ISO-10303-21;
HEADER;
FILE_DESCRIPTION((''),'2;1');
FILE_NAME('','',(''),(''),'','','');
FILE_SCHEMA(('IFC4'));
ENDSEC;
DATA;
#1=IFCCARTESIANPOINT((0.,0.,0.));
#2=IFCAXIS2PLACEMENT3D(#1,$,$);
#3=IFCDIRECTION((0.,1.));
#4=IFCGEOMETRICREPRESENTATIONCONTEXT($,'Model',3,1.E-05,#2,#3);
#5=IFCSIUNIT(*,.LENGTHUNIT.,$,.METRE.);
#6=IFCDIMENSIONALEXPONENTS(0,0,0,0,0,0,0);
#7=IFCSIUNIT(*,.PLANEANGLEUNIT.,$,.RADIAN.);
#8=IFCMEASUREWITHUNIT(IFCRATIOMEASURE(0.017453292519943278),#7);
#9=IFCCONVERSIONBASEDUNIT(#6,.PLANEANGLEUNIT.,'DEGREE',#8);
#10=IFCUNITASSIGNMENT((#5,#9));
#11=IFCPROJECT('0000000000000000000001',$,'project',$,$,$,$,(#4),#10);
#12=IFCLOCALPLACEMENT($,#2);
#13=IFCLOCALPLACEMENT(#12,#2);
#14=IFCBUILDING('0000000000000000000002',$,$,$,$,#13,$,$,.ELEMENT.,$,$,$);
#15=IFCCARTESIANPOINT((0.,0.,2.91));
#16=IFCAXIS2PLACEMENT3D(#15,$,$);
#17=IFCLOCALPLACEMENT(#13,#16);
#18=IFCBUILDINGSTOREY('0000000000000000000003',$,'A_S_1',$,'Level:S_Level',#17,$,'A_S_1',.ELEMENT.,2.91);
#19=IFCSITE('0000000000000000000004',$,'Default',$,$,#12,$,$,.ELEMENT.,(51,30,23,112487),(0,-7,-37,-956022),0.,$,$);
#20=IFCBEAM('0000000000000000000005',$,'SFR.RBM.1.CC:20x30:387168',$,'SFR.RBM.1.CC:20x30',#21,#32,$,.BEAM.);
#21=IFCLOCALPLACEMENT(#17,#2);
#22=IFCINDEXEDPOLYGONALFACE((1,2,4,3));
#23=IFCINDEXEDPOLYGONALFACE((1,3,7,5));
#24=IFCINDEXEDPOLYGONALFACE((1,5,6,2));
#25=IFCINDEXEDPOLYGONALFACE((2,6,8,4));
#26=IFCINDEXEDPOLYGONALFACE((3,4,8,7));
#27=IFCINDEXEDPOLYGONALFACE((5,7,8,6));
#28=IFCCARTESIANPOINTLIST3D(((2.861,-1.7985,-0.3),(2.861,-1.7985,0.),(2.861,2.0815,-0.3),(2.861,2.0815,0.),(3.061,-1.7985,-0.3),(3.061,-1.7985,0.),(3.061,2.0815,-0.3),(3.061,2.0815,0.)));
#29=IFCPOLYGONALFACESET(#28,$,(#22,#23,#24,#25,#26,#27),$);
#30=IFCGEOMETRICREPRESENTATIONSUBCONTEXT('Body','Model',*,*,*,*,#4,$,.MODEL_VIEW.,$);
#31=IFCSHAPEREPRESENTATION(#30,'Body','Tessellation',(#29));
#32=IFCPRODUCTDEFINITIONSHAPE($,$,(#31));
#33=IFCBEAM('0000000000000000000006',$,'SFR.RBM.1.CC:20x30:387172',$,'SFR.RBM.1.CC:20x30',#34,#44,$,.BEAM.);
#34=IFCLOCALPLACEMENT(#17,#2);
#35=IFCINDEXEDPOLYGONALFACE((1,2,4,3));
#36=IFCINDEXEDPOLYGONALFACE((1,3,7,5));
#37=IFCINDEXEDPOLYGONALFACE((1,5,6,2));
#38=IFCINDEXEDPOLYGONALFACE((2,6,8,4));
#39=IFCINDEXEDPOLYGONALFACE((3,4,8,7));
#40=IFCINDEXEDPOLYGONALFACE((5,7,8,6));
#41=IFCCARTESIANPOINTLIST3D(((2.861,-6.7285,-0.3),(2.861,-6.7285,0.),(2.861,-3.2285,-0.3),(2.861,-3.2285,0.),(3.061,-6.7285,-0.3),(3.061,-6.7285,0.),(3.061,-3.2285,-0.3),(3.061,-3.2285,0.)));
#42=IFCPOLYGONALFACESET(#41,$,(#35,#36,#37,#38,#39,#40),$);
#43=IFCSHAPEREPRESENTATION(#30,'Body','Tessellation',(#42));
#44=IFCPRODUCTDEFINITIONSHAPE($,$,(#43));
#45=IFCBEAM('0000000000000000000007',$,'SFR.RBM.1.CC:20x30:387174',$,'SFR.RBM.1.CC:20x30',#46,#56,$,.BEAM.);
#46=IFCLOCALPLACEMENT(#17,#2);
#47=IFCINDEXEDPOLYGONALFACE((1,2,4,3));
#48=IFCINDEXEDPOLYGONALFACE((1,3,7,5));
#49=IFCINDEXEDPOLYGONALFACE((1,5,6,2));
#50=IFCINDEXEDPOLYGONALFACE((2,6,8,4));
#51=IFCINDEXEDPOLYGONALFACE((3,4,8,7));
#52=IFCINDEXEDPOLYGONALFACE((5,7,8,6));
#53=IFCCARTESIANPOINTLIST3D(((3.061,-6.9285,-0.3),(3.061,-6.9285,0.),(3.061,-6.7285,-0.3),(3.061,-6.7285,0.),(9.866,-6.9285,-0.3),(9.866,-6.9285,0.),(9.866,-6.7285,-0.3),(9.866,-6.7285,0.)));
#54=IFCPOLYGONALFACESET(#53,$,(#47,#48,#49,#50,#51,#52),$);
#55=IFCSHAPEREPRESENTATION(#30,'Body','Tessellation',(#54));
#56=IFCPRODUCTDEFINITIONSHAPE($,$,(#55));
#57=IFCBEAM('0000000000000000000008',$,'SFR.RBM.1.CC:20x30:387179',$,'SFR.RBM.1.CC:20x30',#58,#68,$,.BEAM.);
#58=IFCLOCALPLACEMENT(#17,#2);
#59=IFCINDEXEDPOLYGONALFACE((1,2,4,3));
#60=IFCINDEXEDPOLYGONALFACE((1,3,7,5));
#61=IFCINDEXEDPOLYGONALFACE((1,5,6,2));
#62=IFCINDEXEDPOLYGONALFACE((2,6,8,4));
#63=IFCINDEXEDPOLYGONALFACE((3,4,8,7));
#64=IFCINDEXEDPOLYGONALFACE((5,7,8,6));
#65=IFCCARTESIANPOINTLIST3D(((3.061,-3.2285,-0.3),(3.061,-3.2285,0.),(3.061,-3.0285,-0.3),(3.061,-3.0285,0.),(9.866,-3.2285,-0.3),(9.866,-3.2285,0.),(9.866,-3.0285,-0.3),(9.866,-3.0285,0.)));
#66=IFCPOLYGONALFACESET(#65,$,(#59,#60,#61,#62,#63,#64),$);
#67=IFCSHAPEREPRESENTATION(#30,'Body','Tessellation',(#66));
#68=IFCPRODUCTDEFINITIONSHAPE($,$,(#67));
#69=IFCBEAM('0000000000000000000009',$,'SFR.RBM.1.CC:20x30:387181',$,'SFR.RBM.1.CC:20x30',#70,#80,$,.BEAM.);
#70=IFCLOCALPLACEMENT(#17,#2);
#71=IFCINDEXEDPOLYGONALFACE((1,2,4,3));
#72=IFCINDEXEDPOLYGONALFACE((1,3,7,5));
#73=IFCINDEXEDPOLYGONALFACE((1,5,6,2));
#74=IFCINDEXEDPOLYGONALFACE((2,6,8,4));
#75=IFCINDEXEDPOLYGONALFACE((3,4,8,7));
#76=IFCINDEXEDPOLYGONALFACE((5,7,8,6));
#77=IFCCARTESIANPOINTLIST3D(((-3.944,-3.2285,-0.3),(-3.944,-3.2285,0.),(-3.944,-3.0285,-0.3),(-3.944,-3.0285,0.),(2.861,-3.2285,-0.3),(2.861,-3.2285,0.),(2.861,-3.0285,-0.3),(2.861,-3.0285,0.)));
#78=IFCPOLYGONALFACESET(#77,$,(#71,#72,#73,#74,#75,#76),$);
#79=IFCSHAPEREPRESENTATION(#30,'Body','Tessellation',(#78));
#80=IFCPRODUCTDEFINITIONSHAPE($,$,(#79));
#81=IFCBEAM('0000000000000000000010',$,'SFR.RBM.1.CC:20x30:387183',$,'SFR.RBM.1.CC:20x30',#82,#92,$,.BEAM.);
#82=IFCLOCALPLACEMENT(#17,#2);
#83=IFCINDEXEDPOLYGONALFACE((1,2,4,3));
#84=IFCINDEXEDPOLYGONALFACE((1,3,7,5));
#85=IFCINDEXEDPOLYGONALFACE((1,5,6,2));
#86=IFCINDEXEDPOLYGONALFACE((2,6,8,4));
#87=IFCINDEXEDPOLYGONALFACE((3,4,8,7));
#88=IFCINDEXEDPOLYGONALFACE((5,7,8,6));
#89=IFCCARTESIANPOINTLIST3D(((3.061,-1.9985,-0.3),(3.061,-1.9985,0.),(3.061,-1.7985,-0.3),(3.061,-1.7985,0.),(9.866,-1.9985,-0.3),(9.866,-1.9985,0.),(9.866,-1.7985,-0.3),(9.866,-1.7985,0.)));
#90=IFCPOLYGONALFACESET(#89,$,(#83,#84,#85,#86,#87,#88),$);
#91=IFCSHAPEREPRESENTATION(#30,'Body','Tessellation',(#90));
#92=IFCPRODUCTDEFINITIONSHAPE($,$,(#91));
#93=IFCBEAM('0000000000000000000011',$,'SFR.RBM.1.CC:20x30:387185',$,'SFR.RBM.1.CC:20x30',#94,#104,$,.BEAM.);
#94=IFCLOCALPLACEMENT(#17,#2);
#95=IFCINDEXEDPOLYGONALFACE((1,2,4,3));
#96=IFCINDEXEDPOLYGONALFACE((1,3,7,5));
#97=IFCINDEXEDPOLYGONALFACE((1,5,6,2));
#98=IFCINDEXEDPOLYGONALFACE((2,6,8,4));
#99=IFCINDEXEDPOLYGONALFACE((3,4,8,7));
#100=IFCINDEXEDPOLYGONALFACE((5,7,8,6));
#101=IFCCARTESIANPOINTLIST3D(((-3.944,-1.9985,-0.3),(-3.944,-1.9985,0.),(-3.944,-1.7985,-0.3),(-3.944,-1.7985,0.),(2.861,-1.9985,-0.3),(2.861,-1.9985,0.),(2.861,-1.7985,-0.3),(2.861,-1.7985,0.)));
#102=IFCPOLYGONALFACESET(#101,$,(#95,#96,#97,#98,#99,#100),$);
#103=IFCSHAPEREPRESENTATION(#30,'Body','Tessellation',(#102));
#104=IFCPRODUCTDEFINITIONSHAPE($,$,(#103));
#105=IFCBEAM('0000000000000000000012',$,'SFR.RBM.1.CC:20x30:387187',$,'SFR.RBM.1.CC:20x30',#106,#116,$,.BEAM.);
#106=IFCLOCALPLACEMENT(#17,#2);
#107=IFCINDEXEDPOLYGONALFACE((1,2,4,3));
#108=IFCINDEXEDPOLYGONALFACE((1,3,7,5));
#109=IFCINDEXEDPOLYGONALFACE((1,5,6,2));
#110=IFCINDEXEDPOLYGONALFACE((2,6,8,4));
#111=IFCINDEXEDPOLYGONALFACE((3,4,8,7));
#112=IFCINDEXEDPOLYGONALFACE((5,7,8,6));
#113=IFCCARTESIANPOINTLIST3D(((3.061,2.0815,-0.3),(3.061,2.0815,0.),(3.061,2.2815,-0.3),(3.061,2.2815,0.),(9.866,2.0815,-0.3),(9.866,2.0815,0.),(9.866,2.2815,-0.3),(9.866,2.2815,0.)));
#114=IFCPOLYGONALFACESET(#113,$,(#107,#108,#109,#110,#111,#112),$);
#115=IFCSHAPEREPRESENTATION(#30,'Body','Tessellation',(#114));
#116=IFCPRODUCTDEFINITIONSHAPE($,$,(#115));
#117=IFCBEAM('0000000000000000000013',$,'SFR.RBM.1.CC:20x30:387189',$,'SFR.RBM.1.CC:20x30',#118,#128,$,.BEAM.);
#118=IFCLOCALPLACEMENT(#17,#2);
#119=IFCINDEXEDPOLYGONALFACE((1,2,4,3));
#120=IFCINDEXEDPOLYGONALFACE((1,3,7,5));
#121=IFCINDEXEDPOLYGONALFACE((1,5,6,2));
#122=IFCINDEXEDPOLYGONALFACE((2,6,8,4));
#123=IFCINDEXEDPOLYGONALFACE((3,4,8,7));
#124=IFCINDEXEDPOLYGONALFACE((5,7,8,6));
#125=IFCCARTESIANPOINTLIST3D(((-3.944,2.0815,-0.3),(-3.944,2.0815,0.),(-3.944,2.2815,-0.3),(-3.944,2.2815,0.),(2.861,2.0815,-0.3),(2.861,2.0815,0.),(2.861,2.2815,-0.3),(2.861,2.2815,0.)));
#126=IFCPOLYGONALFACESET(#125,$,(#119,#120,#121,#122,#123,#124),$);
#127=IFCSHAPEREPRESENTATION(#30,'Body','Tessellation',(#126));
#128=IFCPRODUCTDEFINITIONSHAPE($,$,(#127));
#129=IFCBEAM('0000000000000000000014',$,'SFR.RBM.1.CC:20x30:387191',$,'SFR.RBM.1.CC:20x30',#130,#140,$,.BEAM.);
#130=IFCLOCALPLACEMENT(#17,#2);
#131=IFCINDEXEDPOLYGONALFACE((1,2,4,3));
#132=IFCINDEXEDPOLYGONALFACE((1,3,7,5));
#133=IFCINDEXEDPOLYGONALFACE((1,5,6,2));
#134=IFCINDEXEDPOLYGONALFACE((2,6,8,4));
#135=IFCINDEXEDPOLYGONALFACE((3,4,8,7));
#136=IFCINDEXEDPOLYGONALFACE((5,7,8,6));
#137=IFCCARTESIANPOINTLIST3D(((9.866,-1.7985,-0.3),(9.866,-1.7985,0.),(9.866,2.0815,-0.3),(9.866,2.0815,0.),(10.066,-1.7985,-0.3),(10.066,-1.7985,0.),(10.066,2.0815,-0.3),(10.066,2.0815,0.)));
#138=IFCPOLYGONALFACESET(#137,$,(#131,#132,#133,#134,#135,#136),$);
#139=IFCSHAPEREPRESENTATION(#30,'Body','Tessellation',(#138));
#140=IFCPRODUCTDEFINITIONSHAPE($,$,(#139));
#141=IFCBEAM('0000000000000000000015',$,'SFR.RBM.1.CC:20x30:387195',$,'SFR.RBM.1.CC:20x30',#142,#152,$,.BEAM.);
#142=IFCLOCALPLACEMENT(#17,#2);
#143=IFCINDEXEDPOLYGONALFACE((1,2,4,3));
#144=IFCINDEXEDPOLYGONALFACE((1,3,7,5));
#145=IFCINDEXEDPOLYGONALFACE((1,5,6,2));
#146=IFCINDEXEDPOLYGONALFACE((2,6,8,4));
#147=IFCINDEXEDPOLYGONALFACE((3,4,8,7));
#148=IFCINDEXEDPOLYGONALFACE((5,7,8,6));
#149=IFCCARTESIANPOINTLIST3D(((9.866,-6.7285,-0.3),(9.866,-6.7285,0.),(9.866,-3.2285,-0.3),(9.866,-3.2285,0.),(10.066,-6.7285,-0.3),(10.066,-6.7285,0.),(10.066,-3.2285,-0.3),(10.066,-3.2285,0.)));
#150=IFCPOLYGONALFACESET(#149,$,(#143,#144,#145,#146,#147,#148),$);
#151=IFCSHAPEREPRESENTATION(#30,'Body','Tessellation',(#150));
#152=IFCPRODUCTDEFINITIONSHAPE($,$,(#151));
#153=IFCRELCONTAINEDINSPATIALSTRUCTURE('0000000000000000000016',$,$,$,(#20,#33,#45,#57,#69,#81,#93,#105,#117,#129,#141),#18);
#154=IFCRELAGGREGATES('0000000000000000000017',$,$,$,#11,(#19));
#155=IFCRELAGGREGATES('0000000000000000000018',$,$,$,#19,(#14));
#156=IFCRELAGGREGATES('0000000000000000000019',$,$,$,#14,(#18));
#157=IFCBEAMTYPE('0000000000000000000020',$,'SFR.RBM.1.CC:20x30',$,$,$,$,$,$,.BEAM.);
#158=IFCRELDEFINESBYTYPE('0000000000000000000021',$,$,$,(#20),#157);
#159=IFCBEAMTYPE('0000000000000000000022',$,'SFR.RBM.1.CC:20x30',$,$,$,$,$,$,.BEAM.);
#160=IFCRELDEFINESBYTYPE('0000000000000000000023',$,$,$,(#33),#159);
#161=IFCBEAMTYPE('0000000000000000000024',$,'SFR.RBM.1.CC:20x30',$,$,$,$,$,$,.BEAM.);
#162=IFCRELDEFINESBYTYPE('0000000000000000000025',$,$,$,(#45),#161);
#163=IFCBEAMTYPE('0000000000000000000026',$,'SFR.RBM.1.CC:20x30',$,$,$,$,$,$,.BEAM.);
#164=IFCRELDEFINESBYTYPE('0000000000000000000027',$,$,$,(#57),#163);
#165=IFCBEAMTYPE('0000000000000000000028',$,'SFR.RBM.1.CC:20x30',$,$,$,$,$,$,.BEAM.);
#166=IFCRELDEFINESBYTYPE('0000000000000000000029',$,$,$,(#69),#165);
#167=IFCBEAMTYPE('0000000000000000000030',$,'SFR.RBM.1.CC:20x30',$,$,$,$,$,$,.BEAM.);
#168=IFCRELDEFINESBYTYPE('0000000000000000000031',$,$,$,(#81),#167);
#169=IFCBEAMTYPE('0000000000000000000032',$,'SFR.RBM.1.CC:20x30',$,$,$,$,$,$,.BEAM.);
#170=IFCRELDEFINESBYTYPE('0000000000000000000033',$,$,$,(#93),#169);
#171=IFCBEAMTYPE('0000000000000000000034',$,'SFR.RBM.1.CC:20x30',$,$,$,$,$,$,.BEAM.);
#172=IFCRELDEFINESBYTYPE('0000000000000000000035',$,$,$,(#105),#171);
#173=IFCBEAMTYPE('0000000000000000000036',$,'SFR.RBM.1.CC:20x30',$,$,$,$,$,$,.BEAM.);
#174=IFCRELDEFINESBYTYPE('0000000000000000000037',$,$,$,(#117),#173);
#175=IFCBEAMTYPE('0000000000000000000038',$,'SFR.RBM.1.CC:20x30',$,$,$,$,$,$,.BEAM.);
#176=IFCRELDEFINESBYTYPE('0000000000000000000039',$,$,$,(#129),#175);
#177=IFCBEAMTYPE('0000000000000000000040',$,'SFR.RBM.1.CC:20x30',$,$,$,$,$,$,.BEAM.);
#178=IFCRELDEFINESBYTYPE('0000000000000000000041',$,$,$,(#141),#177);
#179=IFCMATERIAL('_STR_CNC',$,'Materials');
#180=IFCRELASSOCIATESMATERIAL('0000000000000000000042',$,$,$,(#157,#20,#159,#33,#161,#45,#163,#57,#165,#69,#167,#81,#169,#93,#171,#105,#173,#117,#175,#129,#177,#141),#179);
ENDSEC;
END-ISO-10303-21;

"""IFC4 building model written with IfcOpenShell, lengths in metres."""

from ifc_helpers import new_model, entity, si_unit, converted_unit, direction, frame, origin, place, context, subcontext, project, spatial, indexed_curve, outline, extrude, source, transform, mapped, material, type_object, type_shapes, element, save


model = new_model("IFC4")

# Units and contexts
model_context = context("Model", 3, precision=1e-05, world=origin(), true_north=direction((0.0, 1.0)))
body_context = subcontext(model_context, "Body", "Model", "MODEL_VIEW")
ifc_project = project(units=[si_unit("LENGTHUNIT", "METRE"), converted_unit("PLANEANGLEUNIT", "DEGREE", entity("IfcRatioMeasure", 0.017453292519943278), si_unit("PLANEANGLEUNIT", "RADIAN"), dimensions=[0, 0, 0, 0, 0, 0, 0])], contexts=[model_context])

# Site, building, storey
site_placement = place(None, origin())
site = spatial("IfcSite", under=ifc_project, at=site_placement, Name="Default", CompositionType="ELEMENT", RefLatitude=(51, 30, 23, 112487), RefLongitude=(0, -7, -37, -956022), RefElevation=0.0)
building_placement = place(site_placement, origin())
building = spatial("IfcBuilding", under=site, at=building_placement, CompositionType="ELEMENT")
storey_placement = place(building_placement, frame((0.0, 0.0, 2.91)))
storey = spatial("IfcBuildingStorey", under=building, at=storey_placement, Name="A_S_1", ObjectType="Level:S_Level", LongName="A_S_1", CompositionType="ELEMENT", Elevation=2.91)

# Shared definitions
ifc_material_1 = material(Name="_STR_CNC", Category="Materials")

# Beams
beam_type_1 = type_object("IfcBeamType", Name="SFR.RBM.1.CC:20x30", PredefinedType="BEAM", material=ifc_material_1)
shared_shape_1 = source(origin(), body_context, "Body", "SweptSolid", [
    extrude(outline(indexed_curve([(-0.1, -0.15), (0.1, -0.15), (0.1, 0.15), (-0.1, 0.15), (-0.1, -0.15)], self_intersect=False)), frame((2.961, 2.0815, 2.76), z_axis=(0.0, -1.0, 0.0), x_axis=(-1.0, 0.0, 0.0)), (0.0, 0.0, 1.0), 3.88),
])
type_shapes(beam_type_1, [shared_shape_1])
beam_1_placement = place(storey_placement, frame((0.0, 0.0, -2.91)))
element("IfcBeam", 1, at=beam_1_placement, inside=storey, type_object=beam_type_1, material=ifc_material_1, Name="SFR.RBM.1.CC:20x30:387168", ObjectType="SFR.RBM.1.CC:20x30", PredefinedType="BEAM", context=body_context, shape_type="MappedRepresentation", body=[
    mapped(shared_shape_1, transform((0.0, 0.0, 0.0), scale=1.0)),
])
beam_type_2 = type_object("IfcBeamType", Name="SFR.RBM.1.CC:20x30", PredefinedType="BEAM", material=ifc_material_1)
shared_shape_2 = source(origin(), body_context, "Body", "SweptSolid", [
    extrude(outline(indexed_curve([(-0.1, -0.15), (0.1, -0.15), (0.1, 0.15), (-0.1, 0.15), (-0.1, -0.15)], self_intersect=False)), frame((2.961, -3.2285, 2.76), z_axis=(0.0, -1.0, 0.0), x_axis=(-1.0, 0.0, 0.0)), (0.0, 0.0, 1.0), 3.5),
])
type_shapes(beam_type_2, [shared_shape_2])
beam_2_placement = place(storey_placement, frame((0.0, 0.0, -2.91)))
element("IfcBeam", 2, at=beam_2_placement, inside=storey, type_object=beam_type_2, material=ifc_material_1, Name="SFR.RBM.1.CC:20x30:387172", ObjectType="SFR.RBM.1.CC:20x30", PredefinedType="BEAM", context=body_context, shape_type="MappedRepresentation", body=[
    mapped(shared_shape_2, transform((0.0, 0.0, 0.0), scale=1.0)),
])
beam_type_3 = type_object("IfcBeamType", Name="SFR.RBM.1.CC:20x30", PredefinedType="BEAM", material=ifc_material_1)
shared_shape_3 = source(origin(), body_context, "Body", "SweptSolid", [
    extrude(outline(indexed_curve([(-0.15, -0.1), (0.15, -0.1), (0.15, 0.1), (-0.15, 0.1), (-0.15, -0.1)], self_intersect=False)), frame((9.866, -6.8285, 2.76), z_axis=(-1.0, 0.0, 0.0), x_axis=(0.0, 0.0, -1.0)), (0.0, 0.0, 1.0), 6.805),
])
type_shapes(beam_type_3, [shared_shape_3])
beam_3_placement = place(storey_placement, frame((0.0, 0.0, -2.91)))
element("IfcBeam", 3, at=beam_3_placement, inside=storey, type_object=beam_type_3, material=ifc_material_1, Name="SFR.RBM.1.CC:20x30:387174", ObjectType="SFR.RBM.1.CC:20x30", PredefinedType="BEAM", context=body_context, shape_type="MappedRepresentation", body=[
    mapped(shared_shape_3, transform((0.0, 0.0, 0.0), scale=1.0)),
])
beam_type_4 = type_object("IfcBeamType", Name="SFR.RBM.1.CC:20x30", PredefinedType="BEAM", material=ifc_material_1)
shared_shape_4 = source(origin(), body_context, "Body", "SweptSolid", [
    extrude(outline(indexed_curve([(-0.15, -0.1), (0.15, -0.1), (0.15, 0.1), (-0.15, 0.1), (-0.15, -0.1)], self_intersect=False)), frame((9.866, -3.1285, 2.76), z_axis=(-1.0, 0.0, 0.0), x_axis=(0.0, 0.0, -1.0)), (0.0, 0.0, 1.0), 6.805),
])
type_shapes(beam_type_4, [shared_shape_4])
beam_4_placement = place(storey_placement, frame((0.0, 0.0, -2.91)))
element("IfcBeam", 4, at=beam_4_placement, inside=storey, type_object=beam_type_4, material=ifc_material_1, Name="SFR.RBM.1.CC:20x30:387179", ObjectType="SFR.RBM.1.CC:20x30", PredefinedType="BEAM", context=body_context, shape_type="MappedRepresentation", body=[
    mapped(shared_shape_4, transform((0.0, 0.0, 0.0), scale=1.0)),
])
beam_type_5 = type_object("IfcBeamType", Name="SFR.RBM.1.CC:20x30", PredefinedType="BEAM", material=ifc_material_1)
shared_shape_5 = source(origin(), body_context, "Body", "SweptSolid", [
    extrude(outline(indexed_curve([(-0.15, -0.1), (0.15, -0.1), (0.15, 0.1), (-0.15, 0.1), (-0.15, -0.1)], self_intersect=False)), frame((2.861, -3.1285, 2.76), z_axis=(-1.0, 0.0, 0.0), x_axis=(0.0, 0.0, -1.0)), (0.0, 0.0, 1.0), 6.805),
])
type_shapes(beam_type_5, [shared_shape_5])
beam_5_placement = place(storey_placement, frame((0.0, 0.0, -2.91)))
element("IfcBeam", 5, at=beam_5_placement, inside=storey, type_object=beam_type_5, material=ifc_material_1, Name="SFR.RBM.1.CC:20x30:387181", ObjectType="SFR.RBM.1.CC:20x30", PredefinedType="BEAM", context=body_context, shape_type="MappedRepresentation", body=[
    mapped(shared_shape_5, transform((0.0, 0.0, 0.0), scale=1.0)),
])
beam_type_6 = type_object("IfcBeamType", Name="SFR.RBM.1.CC:20x30", PredefinedType="BEAM", material=ifc_material_1)
shared_shape_6 = source(origin(), body_context, "Body", "SweptSolid", [
    extrude(outline(indexed_curve([(-0.15, -0.1), (0.15, -0.1), (0.15, 0.1), (-0.15, 0.1), (-0.15, -0.1)], self_intersect=False)), frame((9.866, -1.8985, 2.76), z_axis=(-1.0, 0.0, 0.0), x_axis=(0.0, 0.0, -1.0)), (0.0, 0.0, 1.0), 6.805),
])
type_shapes(beam_type_6, [shared_shape_6])
beam_6_placement = place(storey_placement, frame((0.0, 0.0, -2.91)))
element("IfcBeam", 6, at=beam_6_placement, inside=storey, type_object=beam_type_6, material=ifc_material_1, Name="SFR.RBM.1.CC:20x30:387183", ObjectType="SFR.RBM.1.CC:20x30", PredefinedType="BEAM", context=body_context, shape_type="MappedRepresentation", body=[
    mapped(shared_shape_6, transform((0.0, 0.0, 0.0), scale=1.0)),
])
beam_type_7 = type_object("IfcBeamType", Name="SFR.RBM.1.CC:20x30", PredefinedType="BEAM", material=ifc_material_1)
shared_shape_7 = source(origin(), body_context, "Body", "SweptSolid", [
    extrude(outline(indexed_curve([(-0.15, -0.1), (0.15, -0.1), (0.15, 0.1), (-0.15, 0.1), (-0.15, -0.1)], self_intersect=False)), frame((2.861, -1.8985, 2.76), z_axis=(-1.0, 0.0, 0.0), x_axis=(0.0, 0.0, -1.0)), (0.0, 0.0, 1.0), 6.805),
])
type_shapes(beam_type_7, [shared_shape_7])
beam_7_placement = place(storey_placement, frame((0.0, 0.0, -2.91)))
element("IfcBeam", 7, at=beam_7_placement, inside=storey, type_object=beam_type_7, material=ifc_material_1, Name="SFR.RBM.1.CC:20x30:387185", ObjectType="SFR.RBM.1.CC:20x30", PredefinedType="BEAM", context=body_context, shape_type="MappedRepresentation", body=[
    mapped(shared_shape_7, transform((0.0, 0.0, 0.0), scale=1.0)),
])
beam_type_8 = type_object("IfcBeamType", Name="SFR.RBM.1.CC:20x30", PredefinedType="BEAM", material=ifc_material_1)
shared_shape_8 = source(origin(), body_context, "Body", "SweptSolid", [
    extrude(outline(indexed_curve([(-0.15, -0.1), (0.15, -0.1), (0.15, 0.1), (-0.15, 0.1), (-0.15, -0.1)], self_intersect=False)), frame((9.866, 2.1815, 2.76), z_axis=(-1.0, 0.0, 0.0), x_axis=(0.0, 0.0, -1.0)), (0.0, 0.0, 1.0), 6.805),
])
type_shapes(beam_type_8, [shared_shape_8])
beam_8_placement = place(storey_placement, frame((0.0, 0.0, -2.91)))
element("IfcBeam", 8, at=beam_8_placement, inside=storey, type_object=beam_type_8, material=ifc_material_1, Name="SFR.RBM.1.CC:20x30:387187", ObjectType="SFR.RBM.1.CC:20x30", PredefinedType="BEAM", context=body_context, shape_type="MappedRepresentation", body=[
    mapped(shared_shape_8, transform((0.0, 0.0, 0.0), scale=1.0)),
])
beam_type_9 = type_object("IfcBeamType", Name="SFR.RBM.1.CC:20x30", PredefinedType="BEAM", material=ifc_material_1)
shared_shape_9 = source(origin(), body_context, "Body", "SweptSolid", [
    extrude(outline(indexed_curve([(-0.15, -0.1), (0.15, -0.1), (0.15, 0.1), (-0.15, 0.1), (-0.15, -0.1)], self_intersect=False)), frame((2.861, 2.1815, 2.76), z_axis=(-1.0, 0.0, 0.0), x_axis=(0.0, 0.0, -1.0)), (0.0, 0.0, 1.0), 6.805),
])
type_shapes(beam_type_9, [shared_shape_9])
beam_9_placement = place(storey_placement, frame((0.0, 0.0, -2.91)))
element("IfcBeam", 9, at=beam_9_placement, inside=storey, type_object=beam_type_9, material=ifc_material_1, Name="SFR.RBM.1.CC:20x30:387189", ObjectType="SFR.RBM.1.CC:20x30", PredefinedType="BEAM", context=body_context, shape_type="MappedRepresentation", body=[
    mapped(shared_shape_9, transform((0.0, 0.0, 0.0), scale=1.0)),
])
beam_type_10 = type_object("IfcBeamType", Name="SFR.RBM.1.CC:20x30", PredefinedType="BEAM", material=ifc_material_1)
shared_shape_10 = source(origin(), body_context, "Body", "SweptSolid", [
    extrude(outline(indexed_curve([(-0.1, -0.15), (0.1, -0.15), (0.1, 0.15), (-0.1, 0.15), (-0.1, -0.15)], self_intersect=False)), frame((9.966, 2.0815, 2.76), z_axis=(0.0, -1.0, 0.0), x_axis=(-1.0, 0.0, 0.0)), (0.0, 0.0, 1.0), 3.88),
])
type_shapes(beam_type_10, [shared_shape_10])
beam_10_placement = place(storey_placement, frame((0.0, 0.0, -2.91)))
element("IfcBeam", 10, at=beam_10_placement, inside=storey, type_object=beam_type_10, material=ifc_material_1, Name="SFR.RBM.1.CC:20x30:387191", ObjectType="SFR.RBM.1.CC:20x30", PredefinedType="BEAM", context=body_context, shape_type="MappedRepresentation", body=[
    mapped(shared_shape_10, transform((0.0, 0.0, 0.0), scale=1.0)),
])
beam_type_11 = type_object("IfcBeamType", Name="SFR.RBM.1.CC:20x30", PredefinedType="BEAM", material=ifc_material_1)
shared_shape_11 = source(origin(), body_context, "Body", "SweptSolid", [
    extrude(outline(indexed_curve([(-0.1, -0.15), (0.1, -0.15), (0.1, 0.15), (-0.1, 0.15), (-0.1, -0.15)], self_intersect=False)), frame((9.966, -3.2285, 2.76), z_axis=(0.0, -1.0, 0.0), x_axis=(-1.0, 0.0, 0.0)), (0.0, 0.0, 1.0), 3.5),
])
type_shapes(beam_type_11, [shared_shape_11])
beam_11_placement = place(storey_placement, frame((0.0, 0.0, -2.91)))
element("IfcBeam", 11, at=beam_11_placement, inside=storey, type_object=beam_type_11, material=ifc_material_1, Name="SFR.RBM.1.CC:20x30:387195", ObjectType="SFR.RBM.1.CC:20x30", PredefinedType="BEAM", context=body_context, shape_type="MappedRepresentation", body=[
    mapped(shared_shape_11, transform((0.0, 0.0, 0.0), scale=1.0)),
])

save(model, "model.ifc")
